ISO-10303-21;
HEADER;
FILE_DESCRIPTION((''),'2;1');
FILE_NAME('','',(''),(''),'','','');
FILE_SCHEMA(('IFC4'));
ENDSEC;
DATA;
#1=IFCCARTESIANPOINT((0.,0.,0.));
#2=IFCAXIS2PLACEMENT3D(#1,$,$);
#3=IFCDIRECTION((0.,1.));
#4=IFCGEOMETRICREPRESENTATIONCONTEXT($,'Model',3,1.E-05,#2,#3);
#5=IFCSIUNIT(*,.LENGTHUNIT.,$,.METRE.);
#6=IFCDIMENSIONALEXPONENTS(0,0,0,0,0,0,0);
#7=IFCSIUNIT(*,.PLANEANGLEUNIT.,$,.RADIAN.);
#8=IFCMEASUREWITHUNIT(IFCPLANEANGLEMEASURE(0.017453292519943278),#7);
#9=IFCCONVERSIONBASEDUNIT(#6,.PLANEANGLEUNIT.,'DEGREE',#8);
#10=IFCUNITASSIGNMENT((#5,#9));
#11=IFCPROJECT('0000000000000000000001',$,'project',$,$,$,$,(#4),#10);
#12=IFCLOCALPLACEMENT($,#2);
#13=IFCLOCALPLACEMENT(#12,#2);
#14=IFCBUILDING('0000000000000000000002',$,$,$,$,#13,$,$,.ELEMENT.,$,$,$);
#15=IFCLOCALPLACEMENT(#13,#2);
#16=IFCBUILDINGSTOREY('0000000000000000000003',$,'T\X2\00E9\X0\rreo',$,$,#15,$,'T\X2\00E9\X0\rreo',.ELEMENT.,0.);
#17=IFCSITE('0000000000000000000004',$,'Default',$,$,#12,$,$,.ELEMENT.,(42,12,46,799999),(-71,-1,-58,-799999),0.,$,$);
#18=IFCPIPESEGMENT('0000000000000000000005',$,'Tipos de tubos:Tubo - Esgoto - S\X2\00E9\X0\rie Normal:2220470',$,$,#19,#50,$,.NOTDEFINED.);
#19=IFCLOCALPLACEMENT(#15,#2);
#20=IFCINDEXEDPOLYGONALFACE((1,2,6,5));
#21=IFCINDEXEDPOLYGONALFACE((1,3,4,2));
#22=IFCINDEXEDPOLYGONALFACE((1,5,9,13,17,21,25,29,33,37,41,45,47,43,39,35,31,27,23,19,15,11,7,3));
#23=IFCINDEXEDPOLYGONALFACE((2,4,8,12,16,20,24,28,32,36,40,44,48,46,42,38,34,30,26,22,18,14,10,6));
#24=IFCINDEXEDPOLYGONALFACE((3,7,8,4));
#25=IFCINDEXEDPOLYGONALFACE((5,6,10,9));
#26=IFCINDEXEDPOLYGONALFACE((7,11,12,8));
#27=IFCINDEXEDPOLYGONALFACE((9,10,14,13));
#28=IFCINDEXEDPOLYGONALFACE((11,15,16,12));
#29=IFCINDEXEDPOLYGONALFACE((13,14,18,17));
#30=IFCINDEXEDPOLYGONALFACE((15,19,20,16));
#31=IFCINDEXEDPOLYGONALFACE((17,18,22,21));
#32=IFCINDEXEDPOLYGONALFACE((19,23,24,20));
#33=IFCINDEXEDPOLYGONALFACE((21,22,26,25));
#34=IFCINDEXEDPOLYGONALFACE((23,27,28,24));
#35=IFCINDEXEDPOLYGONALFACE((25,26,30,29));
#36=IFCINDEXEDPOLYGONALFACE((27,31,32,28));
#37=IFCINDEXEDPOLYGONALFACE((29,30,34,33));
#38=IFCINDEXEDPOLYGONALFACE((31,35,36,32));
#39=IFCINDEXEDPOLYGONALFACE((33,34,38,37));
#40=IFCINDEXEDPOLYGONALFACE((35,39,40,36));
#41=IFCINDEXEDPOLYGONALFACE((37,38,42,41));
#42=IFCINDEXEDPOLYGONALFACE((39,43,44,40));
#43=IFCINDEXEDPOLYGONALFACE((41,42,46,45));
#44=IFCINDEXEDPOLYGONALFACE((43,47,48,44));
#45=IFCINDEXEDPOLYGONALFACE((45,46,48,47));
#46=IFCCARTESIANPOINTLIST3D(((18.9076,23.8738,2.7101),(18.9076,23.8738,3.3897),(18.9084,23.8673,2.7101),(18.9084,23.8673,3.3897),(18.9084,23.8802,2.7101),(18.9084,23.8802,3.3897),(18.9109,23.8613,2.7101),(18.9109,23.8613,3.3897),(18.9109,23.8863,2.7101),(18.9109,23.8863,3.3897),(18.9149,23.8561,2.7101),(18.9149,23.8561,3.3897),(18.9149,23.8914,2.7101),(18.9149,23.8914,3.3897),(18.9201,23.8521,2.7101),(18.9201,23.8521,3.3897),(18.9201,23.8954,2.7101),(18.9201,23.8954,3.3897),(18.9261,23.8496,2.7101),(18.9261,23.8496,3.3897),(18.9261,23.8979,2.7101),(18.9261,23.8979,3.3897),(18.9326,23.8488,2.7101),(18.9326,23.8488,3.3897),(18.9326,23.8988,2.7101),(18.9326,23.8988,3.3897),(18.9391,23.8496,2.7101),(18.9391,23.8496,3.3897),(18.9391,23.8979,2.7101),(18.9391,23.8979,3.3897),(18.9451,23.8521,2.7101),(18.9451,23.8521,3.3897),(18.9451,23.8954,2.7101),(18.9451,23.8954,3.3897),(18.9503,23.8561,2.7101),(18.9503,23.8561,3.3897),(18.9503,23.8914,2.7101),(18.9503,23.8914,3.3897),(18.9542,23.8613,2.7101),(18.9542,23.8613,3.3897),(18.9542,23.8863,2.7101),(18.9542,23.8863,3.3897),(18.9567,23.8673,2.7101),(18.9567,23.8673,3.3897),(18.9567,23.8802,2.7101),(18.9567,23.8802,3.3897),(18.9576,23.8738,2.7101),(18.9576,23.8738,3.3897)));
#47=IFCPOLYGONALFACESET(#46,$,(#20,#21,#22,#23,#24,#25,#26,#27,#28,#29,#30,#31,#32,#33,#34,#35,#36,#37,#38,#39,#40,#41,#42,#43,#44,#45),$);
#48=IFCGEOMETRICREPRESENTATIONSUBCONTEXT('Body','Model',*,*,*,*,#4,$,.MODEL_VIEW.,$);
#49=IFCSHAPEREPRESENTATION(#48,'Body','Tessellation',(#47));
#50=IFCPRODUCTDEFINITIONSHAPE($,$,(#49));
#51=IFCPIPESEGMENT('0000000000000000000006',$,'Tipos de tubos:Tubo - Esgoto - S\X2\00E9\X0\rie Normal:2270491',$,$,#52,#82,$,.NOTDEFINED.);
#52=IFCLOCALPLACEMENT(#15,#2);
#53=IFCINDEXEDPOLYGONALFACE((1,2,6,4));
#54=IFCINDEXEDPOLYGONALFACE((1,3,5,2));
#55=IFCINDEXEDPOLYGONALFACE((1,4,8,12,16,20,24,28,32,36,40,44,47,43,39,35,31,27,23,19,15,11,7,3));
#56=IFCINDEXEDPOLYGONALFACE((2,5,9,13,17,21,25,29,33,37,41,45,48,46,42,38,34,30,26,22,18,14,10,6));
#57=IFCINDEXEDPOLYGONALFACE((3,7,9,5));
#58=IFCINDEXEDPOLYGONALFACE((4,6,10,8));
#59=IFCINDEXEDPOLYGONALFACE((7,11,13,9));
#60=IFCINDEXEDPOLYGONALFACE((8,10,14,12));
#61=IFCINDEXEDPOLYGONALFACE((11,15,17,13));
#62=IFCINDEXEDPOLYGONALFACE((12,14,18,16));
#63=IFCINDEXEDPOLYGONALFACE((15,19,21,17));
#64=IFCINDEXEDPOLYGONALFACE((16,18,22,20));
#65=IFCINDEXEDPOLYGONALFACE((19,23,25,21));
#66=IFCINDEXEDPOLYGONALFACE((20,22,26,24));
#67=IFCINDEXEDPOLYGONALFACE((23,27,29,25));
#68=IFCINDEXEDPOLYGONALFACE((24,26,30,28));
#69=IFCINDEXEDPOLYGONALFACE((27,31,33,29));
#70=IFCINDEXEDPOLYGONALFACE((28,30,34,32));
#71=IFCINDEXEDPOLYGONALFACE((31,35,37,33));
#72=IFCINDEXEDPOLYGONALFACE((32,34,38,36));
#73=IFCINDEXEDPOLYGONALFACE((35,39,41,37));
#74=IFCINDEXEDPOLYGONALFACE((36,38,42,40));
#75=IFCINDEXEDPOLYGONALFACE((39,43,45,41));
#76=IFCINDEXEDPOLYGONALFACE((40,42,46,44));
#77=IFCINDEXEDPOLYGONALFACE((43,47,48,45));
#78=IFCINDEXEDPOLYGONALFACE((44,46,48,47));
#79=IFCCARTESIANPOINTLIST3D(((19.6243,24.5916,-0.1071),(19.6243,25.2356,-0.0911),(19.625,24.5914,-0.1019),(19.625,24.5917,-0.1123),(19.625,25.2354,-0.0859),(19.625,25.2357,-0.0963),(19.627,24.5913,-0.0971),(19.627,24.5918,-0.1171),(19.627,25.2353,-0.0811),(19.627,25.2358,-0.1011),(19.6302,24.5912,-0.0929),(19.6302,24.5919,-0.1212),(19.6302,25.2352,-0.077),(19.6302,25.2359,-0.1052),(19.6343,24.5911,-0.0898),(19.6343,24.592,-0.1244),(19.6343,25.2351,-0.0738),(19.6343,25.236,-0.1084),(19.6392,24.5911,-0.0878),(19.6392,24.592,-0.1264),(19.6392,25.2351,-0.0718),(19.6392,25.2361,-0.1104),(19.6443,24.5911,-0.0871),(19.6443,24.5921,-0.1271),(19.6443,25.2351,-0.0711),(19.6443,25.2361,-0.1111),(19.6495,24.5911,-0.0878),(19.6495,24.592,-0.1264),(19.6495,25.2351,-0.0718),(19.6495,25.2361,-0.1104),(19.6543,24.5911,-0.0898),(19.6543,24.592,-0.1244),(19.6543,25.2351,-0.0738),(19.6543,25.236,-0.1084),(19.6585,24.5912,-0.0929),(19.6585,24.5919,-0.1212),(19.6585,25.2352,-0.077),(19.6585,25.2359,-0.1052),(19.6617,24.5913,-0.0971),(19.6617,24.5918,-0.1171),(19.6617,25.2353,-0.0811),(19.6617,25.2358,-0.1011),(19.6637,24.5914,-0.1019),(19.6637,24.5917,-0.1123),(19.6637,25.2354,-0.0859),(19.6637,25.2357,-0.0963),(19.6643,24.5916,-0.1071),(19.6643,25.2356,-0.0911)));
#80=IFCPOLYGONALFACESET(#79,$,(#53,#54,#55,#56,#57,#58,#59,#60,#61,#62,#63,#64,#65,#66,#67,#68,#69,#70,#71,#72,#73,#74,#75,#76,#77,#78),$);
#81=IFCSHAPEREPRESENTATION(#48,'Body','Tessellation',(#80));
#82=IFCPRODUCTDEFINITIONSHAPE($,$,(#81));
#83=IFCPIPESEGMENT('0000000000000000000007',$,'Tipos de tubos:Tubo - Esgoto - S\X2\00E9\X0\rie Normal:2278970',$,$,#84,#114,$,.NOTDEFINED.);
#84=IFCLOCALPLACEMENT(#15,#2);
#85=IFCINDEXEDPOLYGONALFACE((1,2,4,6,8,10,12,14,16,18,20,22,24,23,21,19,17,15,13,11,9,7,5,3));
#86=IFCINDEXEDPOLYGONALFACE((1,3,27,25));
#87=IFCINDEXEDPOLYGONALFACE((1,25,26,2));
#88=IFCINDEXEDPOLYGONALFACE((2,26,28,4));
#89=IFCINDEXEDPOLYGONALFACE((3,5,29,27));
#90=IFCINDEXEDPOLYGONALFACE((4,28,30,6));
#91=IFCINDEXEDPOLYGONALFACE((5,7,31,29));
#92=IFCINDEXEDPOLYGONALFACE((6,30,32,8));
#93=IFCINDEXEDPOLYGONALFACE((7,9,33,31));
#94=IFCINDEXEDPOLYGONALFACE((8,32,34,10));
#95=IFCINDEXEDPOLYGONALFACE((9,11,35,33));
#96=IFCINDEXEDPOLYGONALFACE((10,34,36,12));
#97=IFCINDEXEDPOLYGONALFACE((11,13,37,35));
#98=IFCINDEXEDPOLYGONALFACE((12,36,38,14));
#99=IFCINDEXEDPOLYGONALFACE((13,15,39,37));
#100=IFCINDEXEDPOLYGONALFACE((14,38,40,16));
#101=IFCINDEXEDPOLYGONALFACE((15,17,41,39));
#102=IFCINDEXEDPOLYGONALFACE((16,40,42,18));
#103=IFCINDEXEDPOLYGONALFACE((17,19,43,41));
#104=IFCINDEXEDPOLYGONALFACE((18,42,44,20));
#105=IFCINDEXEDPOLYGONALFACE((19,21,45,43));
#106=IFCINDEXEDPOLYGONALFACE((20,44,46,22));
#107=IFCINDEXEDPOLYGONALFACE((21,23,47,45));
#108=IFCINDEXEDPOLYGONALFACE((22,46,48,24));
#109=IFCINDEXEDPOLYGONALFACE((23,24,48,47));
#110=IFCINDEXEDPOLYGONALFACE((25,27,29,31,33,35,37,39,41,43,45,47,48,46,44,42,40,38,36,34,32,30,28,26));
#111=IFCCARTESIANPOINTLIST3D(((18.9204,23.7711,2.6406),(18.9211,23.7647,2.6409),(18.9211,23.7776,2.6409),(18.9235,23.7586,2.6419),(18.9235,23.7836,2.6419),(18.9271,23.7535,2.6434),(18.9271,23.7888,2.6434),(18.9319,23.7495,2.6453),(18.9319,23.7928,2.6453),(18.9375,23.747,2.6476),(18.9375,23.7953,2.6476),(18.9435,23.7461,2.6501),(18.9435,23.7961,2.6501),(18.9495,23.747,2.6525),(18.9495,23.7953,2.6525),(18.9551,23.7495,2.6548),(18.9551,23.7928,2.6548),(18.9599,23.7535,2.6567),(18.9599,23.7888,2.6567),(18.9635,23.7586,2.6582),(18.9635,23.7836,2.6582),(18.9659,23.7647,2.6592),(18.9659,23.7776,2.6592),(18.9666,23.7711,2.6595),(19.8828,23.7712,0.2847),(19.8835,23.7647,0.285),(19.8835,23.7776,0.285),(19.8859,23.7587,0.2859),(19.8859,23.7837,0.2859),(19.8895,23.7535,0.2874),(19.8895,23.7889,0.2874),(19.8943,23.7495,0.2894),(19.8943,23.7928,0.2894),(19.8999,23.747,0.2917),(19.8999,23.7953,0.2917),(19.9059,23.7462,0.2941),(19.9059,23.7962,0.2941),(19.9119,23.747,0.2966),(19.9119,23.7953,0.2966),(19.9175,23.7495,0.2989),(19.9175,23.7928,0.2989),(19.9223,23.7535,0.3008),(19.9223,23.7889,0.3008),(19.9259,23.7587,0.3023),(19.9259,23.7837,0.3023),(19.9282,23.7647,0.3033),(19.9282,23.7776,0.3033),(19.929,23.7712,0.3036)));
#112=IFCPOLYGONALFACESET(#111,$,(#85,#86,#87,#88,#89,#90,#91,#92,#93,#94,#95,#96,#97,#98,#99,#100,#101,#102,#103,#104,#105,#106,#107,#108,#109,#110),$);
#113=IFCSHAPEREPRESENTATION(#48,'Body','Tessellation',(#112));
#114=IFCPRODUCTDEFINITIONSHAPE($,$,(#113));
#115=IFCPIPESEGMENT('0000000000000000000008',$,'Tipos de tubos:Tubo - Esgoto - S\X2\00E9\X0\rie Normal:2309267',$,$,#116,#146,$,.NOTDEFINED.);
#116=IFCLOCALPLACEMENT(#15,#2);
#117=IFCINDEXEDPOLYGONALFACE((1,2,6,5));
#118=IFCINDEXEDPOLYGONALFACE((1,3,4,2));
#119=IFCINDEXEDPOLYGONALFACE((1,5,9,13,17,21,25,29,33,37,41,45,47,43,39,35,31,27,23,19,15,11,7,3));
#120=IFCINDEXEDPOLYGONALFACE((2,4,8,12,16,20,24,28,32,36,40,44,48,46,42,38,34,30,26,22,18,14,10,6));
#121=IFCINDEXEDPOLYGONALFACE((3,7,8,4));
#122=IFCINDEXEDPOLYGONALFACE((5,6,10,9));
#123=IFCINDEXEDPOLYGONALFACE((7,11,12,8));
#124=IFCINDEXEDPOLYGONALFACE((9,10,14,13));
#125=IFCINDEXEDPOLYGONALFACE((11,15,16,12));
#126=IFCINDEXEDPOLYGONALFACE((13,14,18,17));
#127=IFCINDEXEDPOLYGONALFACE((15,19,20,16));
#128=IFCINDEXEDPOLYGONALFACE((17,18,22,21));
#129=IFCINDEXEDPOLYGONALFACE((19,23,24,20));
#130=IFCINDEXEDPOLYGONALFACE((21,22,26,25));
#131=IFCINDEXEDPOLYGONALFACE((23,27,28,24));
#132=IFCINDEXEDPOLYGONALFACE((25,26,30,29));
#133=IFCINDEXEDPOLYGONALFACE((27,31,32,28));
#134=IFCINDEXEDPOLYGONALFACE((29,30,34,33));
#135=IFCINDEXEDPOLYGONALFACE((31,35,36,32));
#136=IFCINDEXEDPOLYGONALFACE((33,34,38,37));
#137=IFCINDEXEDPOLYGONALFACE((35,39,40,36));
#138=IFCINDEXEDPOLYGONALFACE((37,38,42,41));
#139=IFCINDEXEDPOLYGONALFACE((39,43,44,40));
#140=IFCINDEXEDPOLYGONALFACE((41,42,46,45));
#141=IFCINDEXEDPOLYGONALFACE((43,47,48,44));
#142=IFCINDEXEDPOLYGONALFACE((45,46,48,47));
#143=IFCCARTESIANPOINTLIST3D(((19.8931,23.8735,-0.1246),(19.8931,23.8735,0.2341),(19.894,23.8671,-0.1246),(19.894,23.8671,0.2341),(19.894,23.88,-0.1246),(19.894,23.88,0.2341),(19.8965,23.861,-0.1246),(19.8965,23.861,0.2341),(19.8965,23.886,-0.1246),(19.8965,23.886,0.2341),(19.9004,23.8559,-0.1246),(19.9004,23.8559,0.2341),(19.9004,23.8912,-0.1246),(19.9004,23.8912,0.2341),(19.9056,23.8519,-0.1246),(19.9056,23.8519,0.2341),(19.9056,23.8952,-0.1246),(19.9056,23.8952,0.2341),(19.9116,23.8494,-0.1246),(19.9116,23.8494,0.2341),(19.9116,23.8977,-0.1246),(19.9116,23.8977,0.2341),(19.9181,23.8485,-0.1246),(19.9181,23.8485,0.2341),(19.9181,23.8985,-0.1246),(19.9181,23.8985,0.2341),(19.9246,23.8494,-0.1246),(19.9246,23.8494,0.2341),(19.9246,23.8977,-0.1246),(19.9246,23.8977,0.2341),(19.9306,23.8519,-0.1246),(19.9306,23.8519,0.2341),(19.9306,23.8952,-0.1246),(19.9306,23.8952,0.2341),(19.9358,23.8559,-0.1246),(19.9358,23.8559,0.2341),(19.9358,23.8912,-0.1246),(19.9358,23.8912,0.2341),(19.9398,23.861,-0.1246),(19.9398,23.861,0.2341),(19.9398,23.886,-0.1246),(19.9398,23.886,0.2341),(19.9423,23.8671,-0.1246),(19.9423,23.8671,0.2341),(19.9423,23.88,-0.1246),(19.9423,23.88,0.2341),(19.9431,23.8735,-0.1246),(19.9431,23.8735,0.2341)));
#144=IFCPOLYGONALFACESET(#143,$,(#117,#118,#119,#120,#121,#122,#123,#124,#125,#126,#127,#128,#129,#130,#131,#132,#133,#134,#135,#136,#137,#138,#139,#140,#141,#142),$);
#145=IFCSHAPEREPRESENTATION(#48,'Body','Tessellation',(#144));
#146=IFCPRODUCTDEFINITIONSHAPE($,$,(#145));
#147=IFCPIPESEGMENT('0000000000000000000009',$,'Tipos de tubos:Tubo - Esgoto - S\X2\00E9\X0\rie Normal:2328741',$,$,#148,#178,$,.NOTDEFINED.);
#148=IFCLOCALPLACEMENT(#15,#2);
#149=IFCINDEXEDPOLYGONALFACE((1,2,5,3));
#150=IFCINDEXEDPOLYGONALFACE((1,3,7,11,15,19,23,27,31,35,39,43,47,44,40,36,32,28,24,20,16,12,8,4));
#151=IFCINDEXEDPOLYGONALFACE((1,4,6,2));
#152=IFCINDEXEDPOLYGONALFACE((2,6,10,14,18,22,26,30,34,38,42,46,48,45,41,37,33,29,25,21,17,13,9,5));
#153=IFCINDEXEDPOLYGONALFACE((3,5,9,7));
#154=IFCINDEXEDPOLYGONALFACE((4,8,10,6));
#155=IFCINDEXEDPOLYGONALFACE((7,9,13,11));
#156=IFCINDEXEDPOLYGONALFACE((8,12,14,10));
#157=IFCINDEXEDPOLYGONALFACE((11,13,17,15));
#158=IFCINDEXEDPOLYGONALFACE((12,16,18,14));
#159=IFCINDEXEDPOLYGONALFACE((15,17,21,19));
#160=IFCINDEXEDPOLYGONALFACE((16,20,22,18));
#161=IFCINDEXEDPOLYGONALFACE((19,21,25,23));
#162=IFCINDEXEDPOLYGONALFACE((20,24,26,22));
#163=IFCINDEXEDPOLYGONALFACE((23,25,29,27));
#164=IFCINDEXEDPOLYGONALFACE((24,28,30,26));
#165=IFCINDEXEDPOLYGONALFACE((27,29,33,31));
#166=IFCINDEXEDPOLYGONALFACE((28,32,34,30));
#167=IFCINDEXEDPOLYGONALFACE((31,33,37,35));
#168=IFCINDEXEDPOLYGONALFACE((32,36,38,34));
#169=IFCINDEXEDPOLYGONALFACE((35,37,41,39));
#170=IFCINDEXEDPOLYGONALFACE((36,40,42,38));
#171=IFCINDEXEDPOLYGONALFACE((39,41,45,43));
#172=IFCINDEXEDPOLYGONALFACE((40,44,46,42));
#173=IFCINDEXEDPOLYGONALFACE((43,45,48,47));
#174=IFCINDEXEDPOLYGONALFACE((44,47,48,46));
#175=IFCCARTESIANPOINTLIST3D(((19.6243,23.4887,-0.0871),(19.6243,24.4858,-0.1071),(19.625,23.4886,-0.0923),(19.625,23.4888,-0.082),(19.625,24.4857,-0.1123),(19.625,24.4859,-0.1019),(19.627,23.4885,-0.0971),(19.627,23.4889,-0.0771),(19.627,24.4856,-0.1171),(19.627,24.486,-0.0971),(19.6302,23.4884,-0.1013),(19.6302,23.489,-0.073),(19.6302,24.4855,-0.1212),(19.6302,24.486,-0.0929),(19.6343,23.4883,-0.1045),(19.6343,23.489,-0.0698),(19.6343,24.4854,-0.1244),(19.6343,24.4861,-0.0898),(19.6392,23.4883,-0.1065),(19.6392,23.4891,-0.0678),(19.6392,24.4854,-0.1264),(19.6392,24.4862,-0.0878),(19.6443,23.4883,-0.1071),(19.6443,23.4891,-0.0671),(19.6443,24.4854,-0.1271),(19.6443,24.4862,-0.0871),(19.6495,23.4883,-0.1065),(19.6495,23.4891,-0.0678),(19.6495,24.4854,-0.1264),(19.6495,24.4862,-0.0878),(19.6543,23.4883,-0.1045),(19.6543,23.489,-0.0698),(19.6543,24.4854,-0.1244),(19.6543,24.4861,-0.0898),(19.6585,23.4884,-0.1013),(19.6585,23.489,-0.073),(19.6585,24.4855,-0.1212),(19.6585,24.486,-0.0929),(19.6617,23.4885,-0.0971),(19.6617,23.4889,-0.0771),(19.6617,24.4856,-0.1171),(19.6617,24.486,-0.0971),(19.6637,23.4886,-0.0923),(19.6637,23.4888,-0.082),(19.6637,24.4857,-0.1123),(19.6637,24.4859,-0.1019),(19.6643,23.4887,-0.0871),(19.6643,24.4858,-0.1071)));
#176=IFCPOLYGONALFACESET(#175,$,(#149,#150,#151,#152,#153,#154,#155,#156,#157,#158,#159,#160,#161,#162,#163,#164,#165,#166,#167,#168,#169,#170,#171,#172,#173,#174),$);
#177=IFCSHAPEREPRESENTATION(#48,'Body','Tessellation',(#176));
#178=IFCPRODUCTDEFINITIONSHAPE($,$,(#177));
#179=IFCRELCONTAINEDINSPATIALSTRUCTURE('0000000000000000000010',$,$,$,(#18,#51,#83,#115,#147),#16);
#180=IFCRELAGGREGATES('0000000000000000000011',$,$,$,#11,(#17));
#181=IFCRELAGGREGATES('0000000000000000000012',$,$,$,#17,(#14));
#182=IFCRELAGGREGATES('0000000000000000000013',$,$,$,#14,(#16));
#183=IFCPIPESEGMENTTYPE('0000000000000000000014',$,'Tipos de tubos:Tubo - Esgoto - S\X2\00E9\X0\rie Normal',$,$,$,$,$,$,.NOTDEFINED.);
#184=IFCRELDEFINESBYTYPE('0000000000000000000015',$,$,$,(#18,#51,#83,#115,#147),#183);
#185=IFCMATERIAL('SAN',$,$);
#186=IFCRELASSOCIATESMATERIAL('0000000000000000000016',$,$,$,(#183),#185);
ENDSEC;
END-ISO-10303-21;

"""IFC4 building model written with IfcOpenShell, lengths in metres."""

from ifc_helpers import new_model, entity, si_unit, converted_unit, direction, frame, origin, place, context, subcontext, project, spatial, arc, indexed_curve, outline, extrude, material, type_object, element, save


model = new_model("IFC4")

# Units and contexts
model_context = context("Model", 3, precision=1e-05, world=origin(), true_north=direction((0.0, 1.0)))
body_context = subcontext(model_context, "Body", "Model", "MODEL_VIEW")
ifc_project = project(units=[si_unit("LENGTHUNIT", "METRE"), converted_unit("PLANEANGLEUNIT", "DEGREE", entity("IfcPlaneAngleMeasure", 0.017453292519943278), si_unit("PLANEANGLEUNIT", "RADIAN"), dimensions=[0, 0, 0, 0, 0, 0, 0])], contexts=[model_context])

# Site, building, storey
site_placement = place(None, origin())
site = spatial("IfcSite", under=ifc_project, at=site_placement, Name="Default", CompositionType="ELEMENT", RefLatitude=(42, 12, 46, 799999), RefLongitude=(-71, -1, -58, -799999), RefElevation=0.0)
building_placement = place(site_placement, origin())
building = spatial("IfcBuilding", under=site, at=building_placement, CompositionType="ELEMENT")
storey_placement = place(building_placement, origin())
storey = spatial("IfcBuildingStorey", under=building, at=storey_placement, Name="Térreo", LongName="Térreo", CompositionType="ELEMENT", Elevation=0.0)

# Pipe segments
ifc_material_1 = material(Name="SAN")
pipe_segment_type_1 = type_object("IfcPipeSegmentType", Name="Tipos de tubos:Tubo - Esgoto - Série Normal", PredefinedType="NOTDEFINED", material=ifc_material_1)
pipe_segment_1_placement = place(storey_placement, origin())
element("IfcPipeSegment", 1, at=pipe_segment_1_placement, inside=storey, type_object=pipe_segment_type_1, Name="Tipos de tubos:Tubo - Esgoto - Série Normal:2220470", PredefinedType="NOTDEFINED", context=body_context, shape_type="SweptSolid", body=[
    extrude(outline(indexed_curve([(0.025, 0.0), (0.0177, 0.0177), (0.0, 0.025), (-0.0177, 0.0177), (-0.025, 0.0), (-0.0177, -0.0177), (0.0, -0.025), (0.0177, -0.0177)], segments=[arc(1, 2, 3), arc(3, 4, 5), arc(5, 6, 7), arc(7, 8, 1)], self_intersect=False)), frame((18.9326, 23.8738, 2.7101)), (0.0, 0.0, 1.0), 0.6796),
])
pipe_segment_2_placement = place(storey_placement, origin())
element("IfcPipeSegment", 2, at=pipe_segment_2_placement, inside=storey, type_object=pipe_segment_type_1, Name="Tipos de tubos:Tubo - Esgoto - Série Normal:2270491", PredefinedType="NOTDEFINED", context=body_context, shape_type="SweptSolid", body=[
    extrude(outline(indexed_curve([(0.02, 0.0), (0.0141, 0.0141), (0.0, 0.02), (-0.0141, 0.0141), (-0.02, 0.0), (-0.0141, -0.0141), (0.0, -0.02), (0.0141, -0.0141)], segments=[arc(1, 2, 3), arc(3, 4, 5), arc(5, 6, 7), arc(7, 8, 1)], self_intersect=False)), frame((19.6443, 24.5916, -0.1071), z_axis=(0.000003, 0.999693, 0.024786), x_axis=(-1.0, 0.000003, 0.0)), (0.0, 0.0, 1.0), 0.6442),
])
pipe_segment_3_placement = place(storey_placement, origin())
element("IfcPipeSegment", 3, at=pipe_segment_3_placement, inside=storey, type_object=pipe_segment_type_1, Name="Tipos de tubos:Tubo - Esgoto - Série Normal:2278970", PredefinedType="NOTDEFINED", context=body_context, shape_type="SweptSolid", body=[
    extrude(outline(indexed_curve([(0.025, 0.0), (0.0177, 0.0177), (0.0, 0.025), (-0.0177, 0.0177), (-0.025, 0.0), (-0.0177, -0.0177), (0.0, -0.025), (0.0177, -0.0177)], segments=[arc(1, 2, 3), arc(3, 4, 5), arc(5, 6, 7), arc(7, 8, 1)], self_intersect=False)), frame((19.9059, 23.7712, 0.2941), z_axis=(-0.378164, -0.000015, 0.925739), x_axis=(0.000041, -1.0, 0.0)), (0.0, 0.0, 1.0), 2.5449),
])
pipe_segment_4_placement = place(storey_placement, origin())
element("IfcPipeSegment", 4, at=pipe_segment_4_placement, inside=storey, type_object=pipe_segment_type_1, Name="Tipos de tubos:Tubo - Esgoto - Série Normal:2309267", PredefinedType="NOTDEFINED", context=body_context, shape_type="SweptSolid", body=[
    extrude(outline(indexed_curve([(0.025, 0.0), (0.0177, 0.0177), (0.0, 0.025), (-0.0177, 0.0177), (-0.025, 0.0), (-0.0177, -0.0177), (0.0, -0.025), (0.0177, -0.0177)], segments=[arc(1, 2, 3), arc(3, 4, 5), arc(5, 6, 7), arc(7, 8, 1)], self_intersect=False)), frame((19.9181, 23.8735, -0.1246)), (0.0, 0.0, 1.0), 0.3587),
])
pipe_segment_5_placement = place(storey_placement, origin())
element("IfcPipeSegment", 5, at=pipe_segment_5_placement, inside=storey, type_object=pipe_segment_type_1, Name="Tipos de tubos:Tubo - Esgoto - Série Normal:2328741", PredefinedType="NOTDEFINED", context=body_context, shape_type="SweptSolid", body=[
    extrude(outline(indexed_curve([(0.02, 0.0), (0.0141, 0.0141), (0.0, 0.02), (-0.0141, 0.0141), (-0.02, 0.0), (-0.0141, -0.0141), (0.0, -0.02), (0.0141, -0.0141)], segments=[arc(1, 2, 3), arc(3, 4, 5), arc(5, 6, 7), arc(7, 8, 1)], self_intersect=False)), frame((19.6443, 24.4858, -0.1071), z_axis=(0.0, -0.9998, 0.019996), x_axis=(1.0, 0.0, 0.0)), (0.0, 0.0, 1.0), 0.9973),
])

save(model, "model.ifc")
